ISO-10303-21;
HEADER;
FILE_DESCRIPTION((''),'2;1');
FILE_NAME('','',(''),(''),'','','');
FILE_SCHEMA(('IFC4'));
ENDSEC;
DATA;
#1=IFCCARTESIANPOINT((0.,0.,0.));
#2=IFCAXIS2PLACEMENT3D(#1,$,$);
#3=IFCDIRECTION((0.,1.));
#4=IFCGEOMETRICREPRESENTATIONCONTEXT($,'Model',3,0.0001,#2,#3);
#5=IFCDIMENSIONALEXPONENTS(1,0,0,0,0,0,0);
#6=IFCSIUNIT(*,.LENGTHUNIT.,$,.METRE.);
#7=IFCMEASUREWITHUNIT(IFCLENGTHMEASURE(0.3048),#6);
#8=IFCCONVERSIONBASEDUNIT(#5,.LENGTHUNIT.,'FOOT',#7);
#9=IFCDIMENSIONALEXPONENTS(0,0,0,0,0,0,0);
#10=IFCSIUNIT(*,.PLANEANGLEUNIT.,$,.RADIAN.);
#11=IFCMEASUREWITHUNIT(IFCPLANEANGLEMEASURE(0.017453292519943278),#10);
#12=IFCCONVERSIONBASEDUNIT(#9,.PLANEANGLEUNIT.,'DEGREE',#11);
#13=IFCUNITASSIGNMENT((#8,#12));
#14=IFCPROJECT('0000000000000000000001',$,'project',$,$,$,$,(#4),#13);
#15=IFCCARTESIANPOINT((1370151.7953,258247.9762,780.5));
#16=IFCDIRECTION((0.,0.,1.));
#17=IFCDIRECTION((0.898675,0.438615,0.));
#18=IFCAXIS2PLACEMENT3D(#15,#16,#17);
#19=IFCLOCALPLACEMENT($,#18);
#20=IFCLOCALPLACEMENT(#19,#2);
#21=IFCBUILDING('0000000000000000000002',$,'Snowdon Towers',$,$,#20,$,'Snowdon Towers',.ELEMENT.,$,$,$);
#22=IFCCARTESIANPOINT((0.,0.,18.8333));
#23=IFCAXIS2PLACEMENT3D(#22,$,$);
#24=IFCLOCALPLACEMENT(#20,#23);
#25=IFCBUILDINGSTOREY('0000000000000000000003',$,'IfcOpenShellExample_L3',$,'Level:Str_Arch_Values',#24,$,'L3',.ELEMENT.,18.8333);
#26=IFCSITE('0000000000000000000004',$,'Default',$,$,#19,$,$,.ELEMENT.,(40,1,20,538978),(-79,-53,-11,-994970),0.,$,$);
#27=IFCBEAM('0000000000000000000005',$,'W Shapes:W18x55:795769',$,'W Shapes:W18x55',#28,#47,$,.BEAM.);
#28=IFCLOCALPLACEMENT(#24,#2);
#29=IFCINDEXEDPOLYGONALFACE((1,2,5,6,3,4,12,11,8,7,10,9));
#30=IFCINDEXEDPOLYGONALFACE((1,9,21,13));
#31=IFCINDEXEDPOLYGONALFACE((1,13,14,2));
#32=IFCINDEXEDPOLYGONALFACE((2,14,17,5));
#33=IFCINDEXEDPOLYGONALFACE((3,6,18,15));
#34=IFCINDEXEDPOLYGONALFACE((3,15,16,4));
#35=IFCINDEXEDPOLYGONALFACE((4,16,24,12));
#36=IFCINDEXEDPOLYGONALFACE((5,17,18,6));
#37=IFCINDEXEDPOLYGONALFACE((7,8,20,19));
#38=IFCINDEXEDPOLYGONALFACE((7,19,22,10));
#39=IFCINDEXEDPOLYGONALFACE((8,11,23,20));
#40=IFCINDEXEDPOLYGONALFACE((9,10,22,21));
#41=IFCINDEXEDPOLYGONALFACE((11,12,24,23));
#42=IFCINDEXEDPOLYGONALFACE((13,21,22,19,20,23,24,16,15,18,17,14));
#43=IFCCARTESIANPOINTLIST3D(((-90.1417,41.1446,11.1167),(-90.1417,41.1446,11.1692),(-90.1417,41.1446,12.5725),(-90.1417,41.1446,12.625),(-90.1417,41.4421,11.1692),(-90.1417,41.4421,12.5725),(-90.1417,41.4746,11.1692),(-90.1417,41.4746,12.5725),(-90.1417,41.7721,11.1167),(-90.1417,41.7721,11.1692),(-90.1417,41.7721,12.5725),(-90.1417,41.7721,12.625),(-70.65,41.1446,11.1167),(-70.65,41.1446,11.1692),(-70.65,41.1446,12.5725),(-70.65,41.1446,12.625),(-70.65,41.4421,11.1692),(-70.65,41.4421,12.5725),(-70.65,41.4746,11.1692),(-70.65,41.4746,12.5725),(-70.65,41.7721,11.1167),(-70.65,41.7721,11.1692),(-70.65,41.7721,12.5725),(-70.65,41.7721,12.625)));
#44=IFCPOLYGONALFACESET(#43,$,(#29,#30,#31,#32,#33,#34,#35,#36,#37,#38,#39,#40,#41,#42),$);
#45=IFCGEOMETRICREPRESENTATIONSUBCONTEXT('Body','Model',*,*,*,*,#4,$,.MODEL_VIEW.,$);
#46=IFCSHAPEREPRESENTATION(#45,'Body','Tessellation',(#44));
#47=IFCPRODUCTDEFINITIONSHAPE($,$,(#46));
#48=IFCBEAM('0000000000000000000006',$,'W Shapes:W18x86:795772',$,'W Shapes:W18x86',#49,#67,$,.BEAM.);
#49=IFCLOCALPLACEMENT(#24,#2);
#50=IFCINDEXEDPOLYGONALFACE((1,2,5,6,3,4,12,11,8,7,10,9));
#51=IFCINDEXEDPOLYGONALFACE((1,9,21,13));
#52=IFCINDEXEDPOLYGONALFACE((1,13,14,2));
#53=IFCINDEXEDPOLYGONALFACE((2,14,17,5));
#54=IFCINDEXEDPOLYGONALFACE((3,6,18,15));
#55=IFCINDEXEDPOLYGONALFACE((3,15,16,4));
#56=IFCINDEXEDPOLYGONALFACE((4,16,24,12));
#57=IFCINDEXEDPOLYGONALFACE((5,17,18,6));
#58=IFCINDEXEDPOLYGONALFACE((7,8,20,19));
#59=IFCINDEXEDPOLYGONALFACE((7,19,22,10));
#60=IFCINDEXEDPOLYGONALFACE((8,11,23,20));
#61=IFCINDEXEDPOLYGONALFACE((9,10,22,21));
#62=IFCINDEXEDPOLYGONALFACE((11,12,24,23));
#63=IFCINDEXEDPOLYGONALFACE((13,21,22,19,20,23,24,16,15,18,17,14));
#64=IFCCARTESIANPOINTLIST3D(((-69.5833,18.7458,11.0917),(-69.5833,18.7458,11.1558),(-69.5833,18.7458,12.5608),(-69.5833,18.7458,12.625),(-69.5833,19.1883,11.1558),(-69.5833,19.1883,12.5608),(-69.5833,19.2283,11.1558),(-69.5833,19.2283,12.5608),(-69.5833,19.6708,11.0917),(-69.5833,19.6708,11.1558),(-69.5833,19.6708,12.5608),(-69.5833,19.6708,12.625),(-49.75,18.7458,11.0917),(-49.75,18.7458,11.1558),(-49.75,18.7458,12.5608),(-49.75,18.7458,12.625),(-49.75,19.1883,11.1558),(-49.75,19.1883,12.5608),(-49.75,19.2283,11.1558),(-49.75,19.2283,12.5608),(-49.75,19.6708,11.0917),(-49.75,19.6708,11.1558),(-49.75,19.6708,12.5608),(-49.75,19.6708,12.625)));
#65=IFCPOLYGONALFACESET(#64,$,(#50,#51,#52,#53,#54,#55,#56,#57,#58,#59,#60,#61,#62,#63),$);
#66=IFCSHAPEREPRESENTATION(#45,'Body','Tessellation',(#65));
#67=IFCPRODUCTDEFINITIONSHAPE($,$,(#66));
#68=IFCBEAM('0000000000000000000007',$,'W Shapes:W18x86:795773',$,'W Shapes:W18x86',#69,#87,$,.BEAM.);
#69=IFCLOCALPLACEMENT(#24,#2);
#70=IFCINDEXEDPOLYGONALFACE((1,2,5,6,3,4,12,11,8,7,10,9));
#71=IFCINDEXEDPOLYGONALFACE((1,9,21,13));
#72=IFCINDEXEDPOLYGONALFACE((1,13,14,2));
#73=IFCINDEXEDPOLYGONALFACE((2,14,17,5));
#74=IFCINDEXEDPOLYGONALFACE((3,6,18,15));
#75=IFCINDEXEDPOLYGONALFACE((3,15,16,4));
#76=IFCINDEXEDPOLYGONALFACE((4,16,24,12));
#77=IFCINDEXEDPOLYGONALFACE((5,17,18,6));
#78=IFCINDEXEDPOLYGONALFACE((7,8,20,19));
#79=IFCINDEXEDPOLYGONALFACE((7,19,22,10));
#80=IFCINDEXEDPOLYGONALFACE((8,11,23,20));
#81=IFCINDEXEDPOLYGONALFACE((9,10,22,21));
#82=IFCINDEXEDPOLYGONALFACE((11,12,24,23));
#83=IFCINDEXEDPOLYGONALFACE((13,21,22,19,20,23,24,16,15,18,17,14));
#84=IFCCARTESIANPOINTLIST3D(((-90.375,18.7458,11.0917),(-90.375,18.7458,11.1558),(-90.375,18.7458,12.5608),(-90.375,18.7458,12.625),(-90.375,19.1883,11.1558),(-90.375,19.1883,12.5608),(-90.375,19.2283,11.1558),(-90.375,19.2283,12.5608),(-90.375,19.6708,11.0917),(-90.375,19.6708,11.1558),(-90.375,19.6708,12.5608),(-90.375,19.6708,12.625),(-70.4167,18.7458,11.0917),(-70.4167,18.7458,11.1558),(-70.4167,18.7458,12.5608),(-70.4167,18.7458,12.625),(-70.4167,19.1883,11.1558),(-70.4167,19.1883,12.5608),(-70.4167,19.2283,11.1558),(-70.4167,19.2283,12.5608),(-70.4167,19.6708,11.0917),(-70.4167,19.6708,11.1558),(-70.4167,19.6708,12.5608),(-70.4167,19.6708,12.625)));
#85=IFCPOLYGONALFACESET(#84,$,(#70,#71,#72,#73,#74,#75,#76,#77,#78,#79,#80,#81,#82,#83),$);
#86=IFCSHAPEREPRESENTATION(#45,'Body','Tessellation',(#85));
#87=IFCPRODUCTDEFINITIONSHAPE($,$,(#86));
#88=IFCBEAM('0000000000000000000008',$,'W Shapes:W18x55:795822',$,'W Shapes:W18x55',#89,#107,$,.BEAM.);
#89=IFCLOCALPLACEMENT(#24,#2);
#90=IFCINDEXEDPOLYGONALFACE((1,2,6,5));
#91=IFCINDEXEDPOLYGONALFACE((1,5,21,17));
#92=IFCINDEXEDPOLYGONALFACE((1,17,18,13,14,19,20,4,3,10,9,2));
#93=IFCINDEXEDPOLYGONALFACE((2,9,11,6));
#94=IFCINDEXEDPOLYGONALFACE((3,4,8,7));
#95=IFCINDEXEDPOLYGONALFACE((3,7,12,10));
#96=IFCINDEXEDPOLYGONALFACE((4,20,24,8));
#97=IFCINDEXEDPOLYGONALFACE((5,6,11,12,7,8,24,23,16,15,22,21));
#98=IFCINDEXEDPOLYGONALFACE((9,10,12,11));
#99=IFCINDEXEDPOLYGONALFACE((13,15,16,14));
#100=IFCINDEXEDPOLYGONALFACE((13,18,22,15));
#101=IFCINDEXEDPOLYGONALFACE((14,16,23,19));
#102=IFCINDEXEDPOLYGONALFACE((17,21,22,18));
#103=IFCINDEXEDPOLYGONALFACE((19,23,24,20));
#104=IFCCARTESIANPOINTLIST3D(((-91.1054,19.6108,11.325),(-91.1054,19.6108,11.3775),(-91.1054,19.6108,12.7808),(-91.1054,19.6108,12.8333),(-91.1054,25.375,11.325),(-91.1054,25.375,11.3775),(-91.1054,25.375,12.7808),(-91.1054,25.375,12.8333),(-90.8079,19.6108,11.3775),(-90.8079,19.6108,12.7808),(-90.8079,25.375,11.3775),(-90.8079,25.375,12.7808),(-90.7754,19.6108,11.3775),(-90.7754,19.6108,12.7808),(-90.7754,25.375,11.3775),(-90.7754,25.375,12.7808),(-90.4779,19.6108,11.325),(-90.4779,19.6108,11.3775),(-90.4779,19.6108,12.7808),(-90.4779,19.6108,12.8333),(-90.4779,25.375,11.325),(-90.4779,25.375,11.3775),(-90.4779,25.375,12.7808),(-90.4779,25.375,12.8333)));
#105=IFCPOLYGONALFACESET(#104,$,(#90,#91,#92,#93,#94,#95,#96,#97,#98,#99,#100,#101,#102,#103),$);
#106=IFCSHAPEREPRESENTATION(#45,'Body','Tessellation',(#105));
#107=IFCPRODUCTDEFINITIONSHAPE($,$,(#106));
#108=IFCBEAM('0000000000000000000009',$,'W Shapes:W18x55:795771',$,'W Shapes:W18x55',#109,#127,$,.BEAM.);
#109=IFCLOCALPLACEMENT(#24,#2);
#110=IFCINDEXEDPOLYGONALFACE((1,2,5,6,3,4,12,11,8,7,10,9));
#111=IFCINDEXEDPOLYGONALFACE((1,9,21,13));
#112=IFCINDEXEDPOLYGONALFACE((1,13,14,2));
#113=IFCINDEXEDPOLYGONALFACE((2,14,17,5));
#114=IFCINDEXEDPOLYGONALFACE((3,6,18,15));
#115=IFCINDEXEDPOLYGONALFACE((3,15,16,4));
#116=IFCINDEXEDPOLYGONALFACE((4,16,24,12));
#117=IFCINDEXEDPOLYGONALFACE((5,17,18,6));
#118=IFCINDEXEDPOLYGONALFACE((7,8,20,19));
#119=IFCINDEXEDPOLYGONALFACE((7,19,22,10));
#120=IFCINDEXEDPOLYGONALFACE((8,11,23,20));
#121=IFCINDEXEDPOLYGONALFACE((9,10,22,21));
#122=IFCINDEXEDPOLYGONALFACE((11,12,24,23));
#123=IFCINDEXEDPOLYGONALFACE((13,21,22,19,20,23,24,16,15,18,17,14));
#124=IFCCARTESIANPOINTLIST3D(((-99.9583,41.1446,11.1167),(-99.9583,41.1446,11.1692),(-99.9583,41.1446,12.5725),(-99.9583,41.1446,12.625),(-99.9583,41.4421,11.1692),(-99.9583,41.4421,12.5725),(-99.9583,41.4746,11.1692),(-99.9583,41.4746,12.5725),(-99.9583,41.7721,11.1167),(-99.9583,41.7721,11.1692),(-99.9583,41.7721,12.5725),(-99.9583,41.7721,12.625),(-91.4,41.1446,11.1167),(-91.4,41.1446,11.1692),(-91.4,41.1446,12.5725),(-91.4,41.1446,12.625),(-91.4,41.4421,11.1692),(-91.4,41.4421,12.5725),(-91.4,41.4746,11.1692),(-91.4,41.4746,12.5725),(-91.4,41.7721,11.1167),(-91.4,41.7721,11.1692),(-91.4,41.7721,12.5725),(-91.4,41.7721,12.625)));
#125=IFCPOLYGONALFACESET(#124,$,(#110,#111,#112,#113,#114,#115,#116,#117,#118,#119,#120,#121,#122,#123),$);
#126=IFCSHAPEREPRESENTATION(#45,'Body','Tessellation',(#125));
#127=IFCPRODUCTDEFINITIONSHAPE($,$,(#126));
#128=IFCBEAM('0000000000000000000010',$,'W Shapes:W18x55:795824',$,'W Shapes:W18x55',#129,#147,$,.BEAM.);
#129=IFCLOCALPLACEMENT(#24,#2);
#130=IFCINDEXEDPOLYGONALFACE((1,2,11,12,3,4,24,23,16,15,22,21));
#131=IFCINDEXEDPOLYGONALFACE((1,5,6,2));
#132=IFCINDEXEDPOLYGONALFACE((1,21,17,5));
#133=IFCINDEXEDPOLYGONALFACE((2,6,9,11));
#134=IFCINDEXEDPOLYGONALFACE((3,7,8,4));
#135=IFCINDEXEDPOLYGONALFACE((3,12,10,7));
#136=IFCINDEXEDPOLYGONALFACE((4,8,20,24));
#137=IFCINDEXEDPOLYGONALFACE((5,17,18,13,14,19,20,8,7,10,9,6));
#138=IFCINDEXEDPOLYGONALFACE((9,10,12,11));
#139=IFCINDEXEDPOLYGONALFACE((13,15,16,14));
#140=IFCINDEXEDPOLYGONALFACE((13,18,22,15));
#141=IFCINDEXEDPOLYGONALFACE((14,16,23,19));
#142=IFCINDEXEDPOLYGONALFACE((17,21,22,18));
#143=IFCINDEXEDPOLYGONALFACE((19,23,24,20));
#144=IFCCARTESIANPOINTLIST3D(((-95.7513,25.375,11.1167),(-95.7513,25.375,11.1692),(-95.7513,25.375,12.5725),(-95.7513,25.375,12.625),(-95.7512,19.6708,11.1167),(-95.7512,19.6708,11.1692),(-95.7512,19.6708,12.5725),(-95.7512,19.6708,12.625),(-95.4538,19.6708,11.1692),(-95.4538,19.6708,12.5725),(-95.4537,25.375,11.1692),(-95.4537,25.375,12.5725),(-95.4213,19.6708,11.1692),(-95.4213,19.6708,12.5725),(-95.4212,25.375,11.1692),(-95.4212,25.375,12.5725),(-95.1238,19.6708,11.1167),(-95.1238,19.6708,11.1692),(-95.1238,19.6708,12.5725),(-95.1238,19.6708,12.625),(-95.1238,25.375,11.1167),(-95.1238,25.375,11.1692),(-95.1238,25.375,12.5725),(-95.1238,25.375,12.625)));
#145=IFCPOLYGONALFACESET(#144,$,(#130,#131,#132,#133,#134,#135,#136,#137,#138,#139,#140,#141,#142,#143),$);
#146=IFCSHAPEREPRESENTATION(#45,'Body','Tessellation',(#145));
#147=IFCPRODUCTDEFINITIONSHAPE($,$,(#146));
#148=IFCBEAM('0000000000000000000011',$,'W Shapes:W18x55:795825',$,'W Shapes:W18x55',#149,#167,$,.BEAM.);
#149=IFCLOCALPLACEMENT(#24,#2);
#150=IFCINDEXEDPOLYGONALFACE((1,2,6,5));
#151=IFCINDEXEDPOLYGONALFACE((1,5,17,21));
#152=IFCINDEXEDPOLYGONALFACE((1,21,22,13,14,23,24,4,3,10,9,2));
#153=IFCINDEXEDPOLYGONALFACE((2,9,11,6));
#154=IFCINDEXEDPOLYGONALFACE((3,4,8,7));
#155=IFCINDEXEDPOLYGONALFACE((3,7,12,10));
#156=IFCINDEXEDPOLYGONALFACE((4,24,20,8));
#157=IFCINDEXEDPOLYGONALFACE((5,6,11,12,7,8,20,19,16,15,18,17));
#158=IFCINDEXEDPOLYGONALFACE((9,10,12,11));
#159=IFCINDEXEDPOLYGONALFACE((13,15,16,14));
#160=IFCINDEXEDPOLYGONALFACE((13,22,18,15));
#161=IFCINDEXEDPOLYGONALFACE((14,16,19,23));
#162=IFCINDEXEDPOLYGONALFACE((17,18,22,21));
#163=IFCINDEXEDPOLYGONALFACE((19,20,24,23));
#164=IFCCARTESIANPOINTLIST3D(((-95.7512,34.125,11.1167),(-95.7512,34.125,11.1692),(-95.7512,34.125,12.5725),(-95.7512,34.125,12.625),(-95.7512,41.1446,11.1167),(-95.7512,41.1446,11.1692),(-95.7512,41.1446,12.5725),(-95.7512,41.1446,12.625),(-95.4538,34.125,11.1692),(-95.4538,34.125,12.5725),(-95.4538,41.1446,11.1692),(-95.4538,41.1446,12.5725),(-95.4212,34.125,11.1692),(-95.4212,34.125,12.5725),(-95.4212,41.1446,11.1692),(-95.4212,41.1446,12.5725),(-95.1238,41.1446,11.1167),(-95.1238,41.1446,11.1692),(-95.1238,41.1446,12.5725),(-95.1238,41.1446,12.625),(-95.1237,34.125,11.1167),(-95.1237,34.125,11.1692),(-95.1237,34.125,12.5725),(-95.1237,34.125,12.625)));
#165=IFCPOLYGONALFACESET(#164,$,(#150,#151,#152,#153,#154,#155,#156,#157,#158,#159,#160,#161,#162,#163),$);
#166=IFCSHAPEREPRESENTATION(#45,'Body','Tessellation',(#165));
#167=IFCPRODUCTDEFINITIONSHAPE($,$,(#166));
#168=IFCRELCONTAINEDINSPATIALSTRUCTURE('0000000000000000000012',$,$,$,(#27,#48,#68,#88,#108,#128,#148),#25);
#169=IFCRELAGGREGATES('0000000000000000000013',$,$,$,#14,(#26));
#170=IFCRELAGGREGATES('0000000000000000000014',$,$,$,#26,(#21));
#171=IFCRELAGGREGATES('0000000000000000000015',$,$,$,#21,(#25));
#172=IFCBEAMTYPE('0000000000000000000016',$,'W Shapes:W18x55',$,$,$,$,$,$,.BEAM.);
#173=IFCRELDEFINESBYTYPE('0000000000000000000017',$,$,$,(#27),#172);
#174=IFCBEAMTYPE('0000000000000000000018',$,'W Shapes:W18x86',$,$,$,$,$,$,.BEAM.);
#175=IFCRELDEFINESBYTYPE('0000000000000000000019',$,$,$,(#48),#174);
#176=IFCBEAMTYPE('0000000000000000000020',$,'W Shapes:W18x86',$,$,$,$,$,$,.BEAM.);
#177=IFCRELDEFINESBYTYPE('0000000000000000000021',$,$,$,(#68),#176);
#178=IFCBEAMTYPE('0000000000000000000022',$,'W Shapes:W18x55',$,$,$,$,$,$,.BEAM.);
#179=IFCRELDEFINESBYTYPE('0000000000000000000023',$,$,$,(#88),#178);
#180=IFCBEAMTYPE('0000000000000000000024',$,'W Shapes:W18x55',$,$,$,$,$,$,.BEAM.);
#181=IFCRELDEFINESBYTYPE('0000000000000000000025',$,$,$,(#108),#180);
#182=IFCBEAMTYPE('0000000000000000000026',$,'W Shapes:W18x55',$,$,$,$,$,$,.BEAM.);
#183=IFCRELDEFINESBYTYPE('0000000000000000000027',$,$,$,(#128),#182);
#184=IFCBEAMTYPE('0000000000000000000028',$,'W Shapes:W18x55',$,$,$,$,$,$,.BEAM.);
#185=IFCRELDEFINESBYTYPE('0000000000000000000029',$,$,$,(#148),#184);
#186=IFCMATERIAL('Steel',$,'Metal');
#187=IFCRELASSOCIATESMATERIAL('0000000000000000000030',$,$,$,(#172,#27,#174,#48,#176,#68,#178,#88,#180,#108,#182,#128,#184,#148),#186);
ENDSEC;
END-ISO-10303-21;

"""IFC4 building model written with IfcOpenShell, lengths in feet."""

from ifc_helpers import new_model, entity, si_unit, converted_unit, direction, frame, origin, place, context, subcontext, project, spatial, indexed_curve, outline, extrude, source, transform, mapped, material, type_object, type_shapes, element, save


model = new_model("IFC4")

# Units and contexts
model_context = context("Model", 3, precision=0.0001, world=origin(), true_north=direction((0.0, 1.0)))
body_context = subcontext(model_context, "Body", "Model", "MODEL_VIEW")
ifc_project = project(units=[converted_unit("LENGTHUNIT", "FOOT", entity("IfcLengthMeasure", 0.3048), si_unit("LENGTHUNIT", "METRE"), dimensions=[1, 0, 0, 0, 0, 0, 0]), converted_unit("PLANEANGLEUNIT", "DEGREE", entity("IfcPlaneAngleMeasure", 0.017453292519943278), si_unit("PLANEANGLEUNIT", "RADIAN"), dimensions=[0, 0, 0, 0, 0, 0, 0])], contexts=[model_context])

# Site, building, storey
site_placement = place(None, frame((1370151.7953, 258247.9762, 780.5), z_axis=(0.0, 0.0, 1.0), x_axis=(0.898675, 0.438615, 0.0)))
site = spatial("IfcSite", under=ifc_project, at=site_placement, Name="Default", CompositionType="ELEMENT", RefLatitude=(40, 1, 20, 538978), RefLongitude=(-79, -53, -11, -994970), RefElevation=0.0)
building_placement = place(site_placement, origin())
building = spatial("IfcBuilding", under=site, at=building_placement, Name="Snowdon Towers", LongName="Snowdon Towers", CompositionType="ELEMENT")
storey_placement = place(building_placement, frame((0.0, 0.0, 18.8333)))
storey = spatial("IfcBuildingStorey", under=building, at=storey_placement, Name="IfcOpenShellExample_L3", ObjectType="Level:Str_Arch_Values", LongName="L3", CompositionType="ELEMENT", Elevation=18.8333)

# Beams
ifc_material = material(Name="Steel", Category="Metal")
beam_type_1 = type_object("IfcBeamType", Name="W Shapes:W18x55", PredefinedType="BEAM", material=ifc_material)
shared_shape_1 = source(origin(), body_context, "Body", "SweptSolid", [
    extrude(outline(indexed_curve([(-0.3138, -0.7017), (-0.3138, -0.7542), (0.3138, -0.7542), (0.3138, -0.7017), (0.0162, -0.7017), (0.0162, 0.7017), (0.3138, 0.7017), (0.3138, 0.7542), (-0.3137, 0.7542), (-0.3137, 0.7017), (-0.0163, 0.7017), (-0.0163, -0.7017), (-0.3138, -0.7017)], self_intersect=False)), frame((-9.7875, 0.0, 0.0), z_axis=(-1.0, 0.0, 0.0), x_axis=(0.0, -1.0, 0.0)), (0.0, 0.0, -1.0), 19.4917),
])
type_shapes(beam_type_1, [shared_shape_1])
beam_1_placement = place(storey_placement, frame((-80.3542, 41.4583, 11.8708)))
element("IfcBeam", 1, at=beam_1_placement, inside=storey, type_object=beam_type_1, material=ifc_material, Name="W Shapes:W18x55:795769", ObjectType="W Shapes:W18x55", PredefinedType="BEAM", context=body_context, shape_type="MappedRepresentation", body=[
    mapped(shared_shape_1, transform((0.0, 0.0, 0.0), scale=1.0)),
])
beam_type_2 = type_object("IfcBeamType", Name="W Shapes:W18x86", PredefinedType="BEAM", material=ifc_material)
shared_shape_2 = source(origin(), body_context, "Body", "SweptSolid", [
    extrude(outline(indexed_curve([(-0.4625, -0.7025), (-0.4625, -0.7667), (0.4625, -0.7667), (0.4625, -0.7025), (0.02, -0.7025), (0.02, 0.7025), (0.4625, 0.7025), (0.4625, 0.7667), (-0.4625, 0.7667), (-0.4625, 0.7025), (-0.02, 0.7025), (-0.02, -0.7025), (-0.4625, -0.7025)], self_intersect=False)), frame((-9.9583, 0.0, 0.0), z_axis=(-1.0, 0.0, 0.0), x_axis=(0.0, -1.0, 0.0)), (0.0, 0.0, -1.0), 19.8333),
])
type_shapes(beam_type_2, [shared_shape_2])
beam_2_placement = place(storey_placement, frame((-59.625, 19.2083, 11.8583)))
element("IfcBeam", 2, at=beam_2_placement, inside=storey, type_object=beam_type_2, material=ifc_material, Name="W Shapes:W18x86:795772", ObjectType="W Shapes:W18x86", PredefinedType="BEAM", context=body_context, shape_type="MappedRepresentation", body=[
    mapped(shared_shape_2, transform((0.0, 0.0, 0.0), scale=1.0)),
])
beam_type_3 = type_object("IfcBeamType", Name="W Shapes:W18x86", PredefinedType="BEAM", material=ifc_material)
shared_shape_3 = source(origin(), body_context, "Body", "SweptSolid", [
    extrude(outline(indexed_curve([(-0.4625, -0.7025), (-0.4625, -0.7667), (0.4625, -0.7667), (0.4625, -0.7025), (0.02, -0.7025), (0.02, 0.7025), (0.4625, 0.7025), (0.4625, 0.7667), (-0.4625, 0.7667), (-0.4625, 0.7025), (-0.02, 0.7025), (-0.02, -0.7025), (-0.4625, -0.7025)], self_intersect=False)), frame((-10.0, 0.0, 0.0), z_axis=(-1.0, 0.0, 0.0), x_axis=(0.0, -1.0, 0.0)), (0.0, 0.0, -1.0), 19.9583),
])
type_shapes(beam_type_3, [shared_shape_3])
beam_3_placement = place(storey_placement, frame((-80.375, 19.2083, 11.8583)))
element("IfcBeam", 3, at=beam_3_placement, inside=storey, type_object=beam_type_3, material=ifc_material, Name="W Shapes:W18x86:795773", ObjectType="W Shapes:W18x86", PredefinedType="BEAM", context=body_context, shape_type="MappedRepresentation", body=[
    mapped(shared_shape_3, transform((0.0, 0.0, 0.0), scale=1.0)),
])
beam_type_4 = type_object("IfcBeamType", Name="W Shapes:W18x55", PredefinedType="BEAM", material=ifc_material)
shared_shape_4 = source(origin(), body_context, "Body", "SweptSolid", [
    extrude(outline(indexed_curve([(-0.3138, -0.7017), (-0.3138, -0.7542), (0.3138, -0.7542), (0.3138, -0.7017), (0.0162, -0.7017), (0.0162, 0.7017), (0.3138, 0.7017), (0.3138, 0.7542), (-0.3137, 0.7542), (-0.3137, 0.7017), (-0.0163, 0.7017), (-0.0163, -0.7017), (-0.3138, -0.7017)], self_intersect=False)), frame((-2.6737, 0.0, 0.0), z_axis=(-1.0, 0.0, 0.0), x_axis=(0.0, -1.0, 0.0)), (0.0, 0.0, -1.0), 5.7642),
])
type_shapes(beam_type_4, [shared_shape_4])
beam_4_placement = place(storey_placement, frame((-90.7917, 22.2846, 12.0792), z_axis=(0.0, 0.0, 1.0), x_axis=(0.0, 1.0, 0.0)))
element("IfcBeam", 4, at=beam_4_placement, inside=storey, type_object=beam_type_4, material=ifc_material, Name="W Shapes:W18x55:795822", ObjectType="W Shapes:W18x55", PredefinedType="BEAM", context=body_context, shape_type="MappedRepresentation", body=[
    mapped(shared_shape_4, transform((0.0, 0.0, 0.0), scale=1.0)),
])
beam_type_5 = type_object("IfcBeamType", Name="W Shapes:W18x55", PredefinedType="BEAM", material=ifc_material)
shared_shape_5 = source(origin(), body_context, "Body", "SweptSolid", [
    extrude(outline(indexed_curve([(-0.3138, -0.7017), (-0.3138, -0.7542), (0.3138, -0.7542), (0.3138, -0.7017), (0.0162, -0.7017), (0.0162, 0.7017), (0.3138, 0.7017), (0.3138, 0.7542), (-0.3137, 0.7542), (-0.3137, 0.7017), (-0.0163, 0.7017), (-0.0163, -0.7017), (-0.3138, -0.7017)], self_intersect=False)), frame((-4.6042, 0.0, 0.0), z_axis=(-1.0, 0.0, 0.0), x_axis=(0.0, -1.0, 0.0)), (0.0, 0.0, -1.0), 8.5583),
])
type_shapes(beam_type_5, [shared_shape_5])
beam_5_placement = place(storey_placement, frame((-95.3542, 41.4583, 11.8708)))
element("IfcBeam", 5, at=beam_5_placement, inside=storey, type_object=beam_type_5, material=ifc_material, Name="W Shapes:W18x55:795771", ObjectType="W Shapes:W18x55", PredefinedType="BEAM", context=body_context, shape_type="MappedRepresentation", body=[
    mapped(shared_shape_5, transform((0.0, 0.0, 0.0), scale=1.0)),
])
beam_type_6 = type_object("IfcBeamType", Name="W Shapes:W18x55", PredefinedType="BEAM", material=ifc_material)
shared_shape_6 = source(origin(), body_context, "Body", "SweptSolid", [
    extrude(outline(indexed_curve([(-0.3138, -0.7017), (-0.3138, -0.7542), (0.3138, -0.7542), (0.3138, -0.7017), (0.0162, -0.7017), (0.0162, 0.7017), (0.3138, 0.7017), (0.3138, 0.7542), (-0.3137, 0.7542), (-0.3137, 0.7017), (-0.0163, 0.7017), (-0.0163, -0.7017), (-0.3138, -0.7017)], self_intersect=False)), frame((-2.6208, 0.0, 0.0), z_axis=(-1.0, 0.0, 0.0), x_axis=(0.0, -1.0, 0.0)), (0.0, 0.0, -1.0), 5.7042),
])
type_shapes(beam_type_6, [shared_shape_6])
beam_6_placement = place(storey_placement, frame((-95.4375, 22.2917, 11.8708), z_axis=(0.0, 0.0, 1.0), x_axis=(0.0, 1.0, 0.0)))
element("IfcBeam", 6, at=beam_6_placement, inside=storey, type_object=beam_type_6, material=ifc_material, Name="W Shapes:W18x55:795824", ObjectType="W Shapes:W18x55", PredefinedType="BEAM", context=body_context, shape_type="MappedRepresentation", body=[
    mapped(shared_shape_6, transform((0.0, 0.0, 0.0), scale=1.0)),
])
beam_type_7 = type_object("IfcBeamType", Name="W Shapes:W18x55", PredefinedType="BEAM", material=ifc_material)
shared_shape_7 = source(origin(), body_context, "Body", "SweptSolid", [
    extrude(outline(indexed_curve([(-0.3138, -0.7017), (-0.3138, -0.7542), (0.3138, -0.7542), (0.3138, -0.7017), (0.0162, -0.7017), (0.0162, 0.7017), (0.3138, 0.7017), (0.3138, 0.7542), (-0.3137, 0.7542), (-0.3137, 0.7017), (-0.0163, 0.7017), (-0.0163, -0.7017), (-0.3138, -0.7017)], self_intersect=False)), frame((-3.3529, 0.0, 0.0), z_axis=(-1.0, 0.0, 0.0), x_axis=(0.0, -1.0, 0.0)), (0.0, 0.0, -1.0), 7.0196),
])
type_shapes(beam_type_7, [shared_shape_7])
beam_7_placement = place(storey_placement, frame((-95.4375, 37.7917, 11.8708), z_axis=(0.0, 0.0, 1.0), x_axis=(0.0, -1.0, 0.0)))
element("IfcBeam", 7, at=beam_7_placement, inside=storey, type_object=beam_type_7, material=ifc_material, Name="W Shapes:W18x55:795825", ObjectType="W Shapes:W18x55", PredefinedType="BEAM", context=body_context, shape_type="MappedRepresentation", body=[
    mapped(shared_shape_7, transform((0.0, 0.0, 0.0), scale=1.0)),
])

save(model, "model.ifc")
